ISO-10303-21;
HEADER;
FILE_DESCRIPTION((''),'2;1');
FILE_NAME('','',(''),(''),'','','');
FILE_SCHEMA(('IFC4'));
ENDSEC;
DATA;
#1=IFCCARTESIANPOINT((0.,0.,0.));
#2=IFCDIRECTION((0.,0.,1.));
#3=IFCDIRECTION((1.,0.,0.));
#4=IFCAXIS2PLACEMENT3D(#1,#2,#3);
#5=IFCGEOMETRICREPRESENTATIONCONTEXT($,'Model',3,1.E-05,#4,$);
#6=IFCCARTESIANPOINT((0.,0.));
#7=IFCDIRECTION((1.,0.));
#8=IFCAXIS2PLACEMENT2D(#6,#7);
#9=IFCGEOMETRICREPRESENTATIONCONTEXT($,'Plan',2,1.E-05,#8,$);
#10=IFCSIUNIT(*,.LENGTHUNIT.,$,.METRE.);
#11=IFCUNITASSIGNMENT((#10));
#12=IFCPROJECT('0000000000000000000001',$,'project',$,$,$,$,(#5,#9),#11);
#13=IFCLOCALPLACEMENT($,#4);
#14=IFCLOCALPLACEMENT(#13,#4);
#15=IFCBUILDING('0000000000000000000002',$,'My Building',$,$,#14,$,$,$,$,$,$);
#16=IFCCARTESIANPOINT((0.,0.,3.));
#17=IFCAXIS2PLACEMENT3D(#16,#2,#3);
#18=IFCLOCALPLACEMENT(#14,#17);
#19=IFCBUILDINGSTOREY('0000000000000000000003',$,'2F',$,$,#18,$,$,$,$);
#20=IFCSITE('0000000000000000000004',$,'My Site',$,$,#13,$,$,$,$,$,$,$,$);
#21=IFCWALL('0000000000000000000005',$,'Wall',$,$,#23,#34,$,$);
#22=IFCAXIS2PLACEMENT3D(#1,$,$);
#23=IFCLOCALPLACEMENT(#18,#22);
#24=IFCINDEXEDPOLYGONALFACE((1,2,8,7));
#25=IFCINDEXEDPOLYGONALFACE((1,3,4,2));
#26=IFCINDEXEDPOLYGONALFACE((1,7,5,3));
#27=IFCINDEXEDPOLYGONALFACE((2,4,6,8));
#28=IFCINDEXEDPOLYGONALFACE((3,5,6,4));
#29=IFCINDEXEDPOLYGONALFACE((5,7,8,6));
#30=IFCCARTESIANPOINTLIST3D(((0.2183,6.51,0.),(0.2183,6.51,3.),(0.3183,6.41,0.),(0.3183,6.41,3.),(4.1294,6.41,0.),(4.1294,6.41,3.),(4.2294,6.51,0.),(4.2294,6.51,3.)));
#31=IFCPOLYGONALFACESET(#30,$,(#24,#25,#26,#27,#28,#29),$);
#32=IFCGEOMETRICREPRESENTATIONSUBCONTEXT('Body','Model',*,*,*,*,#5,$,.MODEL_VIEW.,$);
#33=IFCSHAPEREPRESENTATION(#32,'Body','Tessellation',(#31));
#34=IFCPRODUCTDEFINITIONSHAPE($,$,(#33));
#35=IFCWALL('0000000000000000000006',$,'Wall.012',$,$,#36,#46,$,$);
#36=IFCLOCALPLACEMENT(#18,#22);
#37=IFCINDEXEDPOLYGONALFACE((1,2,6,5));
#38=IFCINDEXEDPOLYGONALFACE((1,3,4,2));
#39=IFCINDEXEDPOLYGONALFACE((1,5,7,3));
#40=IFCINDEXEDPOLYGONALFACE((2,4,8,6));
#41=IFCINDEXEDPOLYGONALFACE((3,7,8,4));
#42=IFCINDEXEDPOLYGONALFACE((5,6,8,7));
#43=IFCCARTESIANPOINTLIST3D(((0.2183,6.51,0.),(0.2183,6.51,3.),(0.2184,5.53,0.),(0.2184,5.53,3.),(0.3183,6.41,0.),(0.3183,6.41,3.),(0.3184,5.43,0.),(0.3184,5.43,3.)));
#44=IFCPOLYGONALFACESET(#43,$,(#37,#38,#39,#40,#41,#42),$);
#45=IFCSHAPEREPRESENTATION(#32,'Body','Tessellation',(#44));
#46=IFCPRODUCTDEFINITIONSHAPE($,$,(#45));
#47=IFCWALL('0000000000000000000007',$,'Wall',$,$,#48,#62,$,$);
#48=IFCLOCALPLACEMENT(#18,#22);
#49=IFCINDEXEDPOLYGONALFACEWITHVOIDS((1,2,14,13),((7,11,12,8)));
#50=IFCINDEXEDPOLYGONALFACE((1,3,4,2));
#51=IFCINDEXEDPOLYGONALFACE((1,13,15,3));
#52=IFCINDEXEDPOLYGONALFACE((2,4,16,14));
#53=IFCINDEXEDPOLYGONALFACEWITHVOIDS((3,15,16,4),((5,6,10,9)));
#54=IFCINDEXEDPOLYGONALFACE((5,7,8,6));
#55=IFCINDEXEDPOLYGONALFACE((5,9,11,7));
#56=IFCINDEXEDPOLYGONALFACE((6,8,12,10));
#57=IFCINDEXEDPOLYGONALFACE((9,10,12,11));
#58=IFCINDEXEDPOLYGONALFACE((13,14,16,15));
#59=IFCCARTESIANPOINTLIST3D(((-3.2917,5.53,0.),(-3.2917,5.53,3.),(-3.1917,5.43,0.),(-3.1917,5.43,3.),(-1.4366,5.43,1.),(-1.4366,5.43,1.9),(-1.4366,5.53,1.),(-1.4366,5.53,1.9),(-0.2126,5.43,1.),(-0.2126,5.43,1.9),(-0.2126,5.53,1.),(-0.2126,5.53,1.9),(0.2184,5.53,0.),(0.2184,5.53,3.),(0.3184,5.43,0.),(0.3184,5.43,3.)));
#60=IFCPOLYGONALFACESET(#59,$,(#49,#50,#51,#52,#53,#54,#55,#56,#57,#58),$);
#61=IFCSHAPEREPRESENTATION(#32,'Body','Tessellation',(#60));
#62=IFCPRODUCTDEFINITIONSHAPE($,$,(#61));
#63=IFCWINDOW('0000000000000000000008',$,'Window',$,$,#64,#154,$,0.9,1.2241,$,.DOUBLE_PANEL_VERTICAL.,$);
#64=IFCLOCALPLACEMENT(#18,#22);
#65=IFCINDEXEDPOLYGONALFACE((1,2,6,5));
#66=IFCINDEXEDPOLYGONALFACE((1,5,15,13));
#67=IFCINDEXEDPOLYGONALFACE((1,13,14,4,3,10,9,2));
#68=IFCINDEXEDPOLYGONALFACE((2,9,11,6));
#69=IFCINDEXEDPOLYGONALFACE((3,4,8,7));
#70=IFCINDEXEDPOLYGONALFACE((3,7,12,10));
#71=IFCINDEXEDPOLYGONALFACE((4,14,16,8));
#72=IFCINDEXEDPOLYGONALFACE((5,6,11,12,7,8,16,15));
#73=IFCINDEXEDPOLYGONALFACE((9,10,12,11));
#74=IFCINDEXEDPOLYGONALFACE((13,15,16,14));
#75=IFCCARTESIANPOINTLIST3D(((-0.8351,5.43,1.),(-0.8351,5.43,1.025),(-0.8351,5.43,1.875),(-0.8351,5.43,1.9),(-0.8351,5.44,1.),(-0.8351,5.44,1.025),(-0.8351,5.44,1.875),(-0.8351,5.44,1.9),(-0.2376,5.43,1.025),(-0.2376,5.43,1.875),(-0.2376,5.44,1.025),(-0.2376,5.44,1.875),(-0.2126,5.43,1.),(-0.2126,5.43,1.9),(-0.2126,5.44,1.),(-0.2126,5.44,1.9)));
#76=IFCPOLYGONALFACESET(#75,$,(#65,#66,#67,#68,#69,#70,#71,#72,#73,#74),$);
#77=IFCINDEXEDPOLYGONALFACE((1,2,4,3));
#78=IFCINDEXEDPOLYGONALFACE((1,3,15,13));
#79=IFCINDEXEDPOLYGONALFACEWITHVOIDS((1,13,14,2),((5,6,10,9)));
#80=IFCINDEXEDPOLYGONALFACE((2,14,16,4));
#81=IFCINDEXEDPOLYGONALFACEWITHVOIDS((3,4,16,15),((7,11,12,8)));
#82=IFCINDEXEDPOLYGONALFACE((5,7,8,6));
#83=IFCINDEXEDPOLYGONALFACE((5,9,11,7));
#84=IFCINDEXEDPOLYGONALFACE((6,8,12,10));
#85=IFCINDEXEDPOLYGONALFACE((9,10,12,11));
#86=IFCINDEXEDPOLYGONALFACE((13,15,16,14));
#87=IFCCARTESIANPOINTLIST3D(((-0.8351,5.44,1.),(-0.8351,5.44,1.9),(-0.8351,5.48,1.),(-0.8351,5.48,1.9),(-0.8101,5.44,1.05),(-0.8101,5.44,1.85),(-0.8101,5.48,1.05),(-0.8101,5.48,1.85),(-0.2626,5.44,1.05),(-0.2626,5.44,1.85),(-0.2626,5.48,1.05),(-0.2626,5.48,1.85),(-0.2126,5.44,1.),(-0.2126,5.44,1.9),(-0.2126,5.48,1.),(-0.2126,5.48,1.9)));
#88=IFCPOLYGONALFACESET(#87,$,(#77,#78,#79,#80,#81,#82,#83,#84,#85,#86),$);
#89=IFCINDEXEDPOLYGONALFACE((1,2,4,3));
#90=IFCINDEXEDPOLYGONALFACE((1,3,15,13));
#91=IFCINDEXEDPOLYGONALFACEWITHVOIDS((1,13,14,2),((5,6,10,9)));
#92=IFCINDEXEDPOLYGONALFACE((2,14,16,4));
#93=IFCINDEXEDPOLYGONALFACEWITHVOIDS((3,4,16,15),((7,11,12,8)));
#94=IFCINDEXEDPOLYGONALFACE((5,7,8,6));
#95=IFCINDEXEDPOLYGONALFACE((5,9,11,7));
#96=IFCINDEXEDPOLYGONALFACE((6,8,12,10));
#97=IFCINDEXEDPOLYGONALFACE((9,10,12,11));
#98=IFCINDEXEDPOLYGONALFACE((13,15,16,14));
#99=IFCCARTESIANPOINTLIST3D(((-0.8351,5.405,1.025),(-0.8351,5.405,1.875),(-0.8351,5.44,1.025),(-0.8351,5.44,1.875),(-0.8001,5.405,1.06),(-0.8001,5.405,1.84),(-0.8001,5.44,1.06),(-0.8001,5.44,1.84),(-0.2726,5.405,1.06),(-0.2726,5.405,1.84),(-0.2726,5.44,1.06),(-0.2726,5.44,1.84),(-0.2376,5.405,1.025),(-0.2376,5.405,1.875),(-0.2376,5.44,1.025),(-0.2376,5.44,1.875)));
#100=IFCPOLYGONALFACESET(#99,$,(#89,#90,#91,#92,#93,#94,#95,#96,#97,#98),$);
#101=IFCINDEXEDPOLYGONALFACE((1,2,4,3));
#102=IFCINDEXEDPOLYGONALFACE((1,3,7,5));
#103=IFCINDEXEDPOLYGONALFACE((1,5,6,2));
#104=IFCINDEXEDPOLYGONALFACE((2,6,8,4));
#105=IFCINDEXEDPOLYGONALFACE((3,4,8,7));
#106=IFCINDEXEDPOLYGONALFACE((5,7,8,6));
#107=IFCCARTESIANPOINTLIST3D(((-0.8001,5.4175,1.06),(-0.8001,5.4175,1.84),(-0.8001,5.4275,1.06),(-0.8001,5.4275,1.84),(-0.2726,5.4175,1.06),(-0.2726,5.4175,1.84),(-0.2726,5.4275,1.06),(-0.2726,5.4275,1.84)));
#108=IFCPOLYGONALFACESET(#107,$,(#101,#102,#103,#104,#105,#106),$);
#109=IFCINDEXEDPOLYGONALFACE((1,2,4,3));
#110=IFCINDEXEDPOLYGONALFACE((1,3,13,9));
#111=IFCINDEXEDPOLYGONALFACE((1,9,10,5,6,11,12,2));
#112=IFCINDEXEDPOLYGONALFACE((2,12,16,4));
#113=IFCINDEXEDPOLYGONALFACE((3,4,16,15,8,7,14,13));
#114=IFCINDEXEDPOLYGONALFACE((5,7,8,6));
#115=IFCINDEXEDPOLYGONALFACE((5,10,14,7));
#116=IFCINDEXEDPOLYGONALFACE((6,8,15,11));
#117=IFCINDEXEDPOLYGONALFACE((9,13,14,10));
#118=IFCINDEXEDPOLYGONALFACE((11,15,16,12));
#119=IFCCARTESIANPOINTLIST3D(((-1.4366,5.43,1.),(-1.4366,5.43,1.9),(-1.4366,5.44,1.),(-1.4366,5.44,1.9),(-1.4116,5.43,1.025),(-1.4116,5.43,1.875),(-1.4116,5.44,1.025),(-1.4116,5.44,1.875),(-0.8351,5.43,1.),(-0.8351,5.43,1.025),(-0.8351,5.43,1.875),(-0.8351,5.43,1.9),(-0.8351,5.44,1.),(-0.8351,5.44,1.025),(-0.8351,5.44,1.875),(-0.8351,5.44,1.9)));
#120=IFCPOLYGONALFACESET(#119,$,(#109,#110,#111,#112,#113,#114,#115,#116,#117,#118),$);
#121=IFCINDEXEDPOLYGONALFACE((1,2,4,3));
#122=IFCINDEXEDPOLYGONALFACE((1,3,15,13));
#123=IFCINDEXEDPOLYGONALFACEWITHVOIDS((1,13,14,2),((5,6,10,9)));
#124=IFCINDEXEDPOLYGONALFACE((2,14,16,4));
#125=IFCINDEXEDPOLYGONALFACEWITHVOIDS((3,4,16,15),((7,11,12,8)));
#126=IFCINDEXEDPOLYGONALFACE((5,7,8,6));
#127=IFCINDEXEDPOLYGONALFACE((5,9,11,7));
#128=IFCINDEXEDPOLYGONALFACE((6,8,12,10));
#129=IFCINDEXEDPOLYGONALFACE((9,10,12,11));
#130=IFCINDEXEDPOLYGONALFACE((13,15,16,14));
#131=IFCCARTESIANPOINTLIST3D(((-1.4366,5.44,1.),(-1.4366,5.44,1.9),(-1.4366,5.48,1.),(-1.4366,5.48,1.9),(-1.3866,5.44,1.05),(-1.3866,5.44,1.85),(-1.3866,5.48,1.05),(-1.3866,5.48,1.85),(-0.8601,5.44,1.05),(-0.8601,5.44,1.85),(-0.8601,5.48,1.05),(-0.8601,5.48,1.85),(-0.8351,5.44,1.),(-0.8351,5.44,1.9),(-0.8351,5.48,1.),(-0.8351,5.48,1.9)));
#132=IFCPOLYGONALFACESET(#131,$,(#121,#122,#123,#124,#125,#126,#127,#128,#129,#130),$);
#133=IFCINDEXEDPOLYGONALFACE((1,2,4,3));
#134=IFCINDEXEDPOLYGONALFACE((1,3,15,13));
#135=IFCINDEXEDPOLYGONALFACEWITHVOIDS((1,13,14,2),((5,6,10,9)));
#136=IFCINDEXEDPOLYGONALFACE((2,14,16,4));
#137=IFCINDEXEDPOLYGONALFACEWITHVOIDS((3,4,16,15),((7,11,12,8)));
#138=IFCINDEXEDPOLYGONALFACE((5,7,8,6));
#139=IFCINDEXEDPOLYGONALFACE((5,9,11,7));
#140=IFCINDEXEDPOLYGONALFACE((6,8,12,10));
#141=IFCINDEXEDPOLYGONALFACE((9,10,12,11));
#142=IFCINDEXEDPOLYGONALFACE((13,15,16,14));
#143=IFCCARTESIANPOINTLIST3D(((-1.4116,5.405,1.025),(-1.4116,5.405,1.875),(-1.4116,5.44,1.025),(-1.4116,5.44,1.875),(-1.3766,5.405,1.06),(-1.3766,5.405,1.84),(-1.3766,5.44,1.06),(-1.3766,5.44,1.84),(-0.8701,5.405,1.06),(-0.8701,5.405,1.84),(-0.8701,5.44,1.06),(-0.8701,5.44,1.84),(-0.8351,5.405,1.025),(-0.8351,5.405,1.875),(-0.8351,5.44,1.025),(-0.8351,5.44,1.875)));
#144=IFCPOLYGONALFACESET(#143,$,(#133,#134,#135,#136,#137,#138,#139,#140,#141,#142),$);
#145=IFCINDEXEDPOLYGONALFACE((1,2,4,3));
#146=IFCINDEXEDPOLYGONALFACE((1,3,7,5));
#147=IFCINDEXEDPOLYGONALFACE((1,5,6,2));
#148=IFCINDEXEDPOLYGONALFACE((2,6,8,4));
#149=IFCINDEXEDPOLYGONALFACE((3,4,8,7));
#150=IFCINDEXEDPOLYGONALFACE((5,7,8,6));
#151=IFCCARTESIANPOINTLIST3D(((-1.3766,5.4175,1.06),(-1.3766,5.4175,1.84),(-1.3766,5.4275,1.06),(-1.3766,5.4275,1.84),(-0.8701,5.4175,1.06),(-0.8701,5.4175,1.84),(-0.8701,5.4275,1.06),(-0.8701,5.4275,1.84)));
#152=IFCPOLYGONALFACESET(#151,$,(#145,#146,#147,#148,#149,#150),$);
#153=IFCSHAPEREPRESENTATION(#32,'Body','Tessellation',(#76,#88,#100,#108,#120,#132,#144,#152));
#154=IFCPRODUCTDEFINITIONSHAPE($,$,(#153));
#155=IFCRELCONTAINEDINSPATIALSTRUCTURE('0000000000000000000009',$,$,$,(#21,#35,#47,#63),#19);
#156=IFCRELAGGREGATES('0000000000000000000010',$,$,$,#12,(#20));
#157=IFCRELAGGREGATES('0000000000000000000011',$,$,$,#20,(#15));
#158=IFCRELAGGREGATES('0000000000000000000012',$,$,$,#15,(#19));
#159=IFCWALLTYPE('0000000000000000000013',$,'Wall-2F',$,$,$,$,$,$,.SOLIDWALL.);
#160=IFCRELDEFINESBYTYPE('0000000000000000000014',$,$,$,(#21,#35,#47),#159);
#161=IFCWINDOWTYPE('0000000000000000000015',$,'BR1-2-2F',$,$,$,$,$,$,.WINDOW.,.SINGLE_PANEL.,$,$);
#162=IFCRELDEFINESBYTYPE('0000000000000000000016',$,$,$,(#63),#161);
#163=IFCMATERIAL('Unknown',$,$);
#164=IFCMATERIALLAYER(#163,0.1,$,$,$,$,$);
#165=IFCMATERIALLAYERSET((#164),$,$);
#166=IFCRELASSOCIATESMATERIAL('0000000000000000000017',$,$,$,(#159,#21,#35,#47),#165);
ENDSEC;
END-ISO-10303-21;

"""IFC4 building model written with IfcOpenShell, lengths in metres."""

from ifc_helpers import new_model, entity, si_unit, frame, origin_with_axes, origin_2d_with_axis, place, context, subcontext, project, spatial, line, indexed_curve, outline, extrude, shape, source, transform, mapped, material, layer, layer_set, layer_usage, type_object, type_shapes, element, fill, save


model = new_model("IFC4")

# Units and contexts
model_context = context("Model", 3, precision=1e-05, world=origin_with_axes())
plan_context = context("Plan", 2, precision=1e-05, world=origin_2d_with_axis())
body_context_1 = subcontext(model_context, "Body", "Model", "MODEL_VIEW")
body_context_2 = subcontext(plan_context, "Body", "Plan", "PLAN_VIEW")
ifc_project = project(units=[si_unit("LENGTHUNIT", "METRE")], contexts=[model_context, plan_context])

# Site, building, storey
site_placement = place(None, origin_with_axes())
site = spatial("IfcSite", under=ifc_project, at=site_placement, Name="My Site")
building_placement = place(site_placement, origin_with_axes())
building = spatial("IfcBuilding", under=site, at=building_placement, Name="My Building")
storey_placement = place(building_placement, frame((0.0, 0.0, 3.0), z_axis=(0.0, 0.0, 1.0), x_axis=(1.0, 0.0, 0.0)))
storey = spatial("IfcBuildingStorey", under=building, at=storey_placement, Name="2F")

# Walls
ifc_material = material(Name="Unknown")
ifc_layer_1 = layer(ifc_material, 0.1)
ifc_layer_set_1 = layer_set([ifc_layer_1])
ifc_layer_usage_1 = layer_usage(ifc_layer_set_1, "AXIS2", "POSITIVE", 0.0)
wall_type_1 = type_object("IfcWallType", Name="Wall-2F", PredefinedType="SOLIDWALL", material=ifc_layer_set_1)
wall_1_placement = place(storey_placement, frame((4.2294, 6.51, 0.0), z_axis=(0.0, 0.0, 1.0), x_axis=(-1.0, 0.0, 0.0)))
element("IfcWall", 1, at=wall_1_placement, inside=storey, type_object=wall_type_1, material=ifc_layer_usage_1, Name="Wall", context=body_context_1, shape_type="SweptSolid", body=[
    extrude(outline(indexed_curve([(0.0, 0.0), (0.1, 0.1), (3.9111, 0.1), (4.0111, 0.0)], segments=[line(1, 2, 3, 4, 1)])), origin_with_axes(), (0.0, 0.0, 1.0), 3.0),
])
ifc_layer_usage_2 = layer_usage(ifc_layer_set_1, "AXIS2", "POSITIVE", 0.0)
wall_2_placement = place(storey_placement, frame((0.2183, 6.51, 0.0), z_axis=(0.0, 0.0, 1.0), x_axis=(0.0, -1.0, 0.0)))
element("IfcWall", 2, at=wall_2_placement, inside=storey, type_object=wall_type_1, material=ifc_layer_usage_2, Name="Wall.012", context=body_context_1, shape_type="SweptSolid", body=[
    extrude(outline(indexed_curve([(0.0, 0.0), (0.1, 0.1), (1.08, 0.1), (0.98, 0.0)], segments=[line(1, 2, 3, 4, 1)])), origin_with_axes(), (0.0, 0.0, 1.0), 3.0),
])

# Wall, opening, window
ifc_layer_usage_3 = layer_usage(ifc_layer_set_1, "AXIS2", "POSITIVE", 0.0)
wall_3_placement = place(storey_placement, frame((0.2184, 5.53, 0.0), z_axis=(0.0, 0.0, 1.0), x_axis=(-1.0, 0.0, 0.0)))
wall_3 = element("IfcWall", 3, at=wall_3_placement, inside=storey, type_object=wall_type_1, material=ifc_layer_usage_3, Name="Wall", context=body_context_1, shape_type="SweptSolid", body=[
    extrude(outline(indexed_curve([(0.0, 0.0), (-0.1, 0.1), (3.41, 0.1), (3.51, 0.0)], segments=[line(1, 2, 3, 4, 1)])), origin_with_axes(), (0.0, 0.0, 1.0), 3.0),
])
shared_shape_1 = source(origin_with_axes(), body_context_1, "Body", "SweptSolid", [
    extrude(outline(indexed_curve([(0.0, 0.0), (1.2241, 0.0), (1.2241, 0.9), (0.0, 0.9)], segments=[line(1, 2, 3, 4, 1)])), frame((0.0, -0.6, 0.0), z_axis=(0.0, -1.0, 0.0), x_axis=(1.0, 0.0, 0.0)), (0.0, 0.0, -1.0), 1.2),
])
opening_1_placement = place(wall_3_placement, frame((0.4309, 0.0, 1.0), z_axis=(0.0, 0.0, 1.0), x_axis=(1.0, 0.0, 0.0)))
opening_1 = element("IfcOpeningElement", 4, at=opening_1_placement, cuts=wall_3, PredefinedType="OPENING", context=body_context_1, shape_type="MappedRepresentation", body=[
    mapped(shared_shape_1, transform((0.0, 0.0, 0.0), x_axis=(1.0, 0.0, 0.0), y_axis=(0.0, 1.0, 0.0), z_axis=(0.0, 0.0, 1.0), scale=1.0)),
])
window_type_1 = type_object("IfcWindowType", Name="BR1-2-2F", PartitioningType="SINGLE_PANEL", PredefinedType="WINDOW")
shared_shape_2 = source(origin_with_axes(), body_context_1, "Body", "SweptSolid", [
    extrude(outline(indexed_curve([(0.6225, 0.0), (0.0, 0.0), (0.0, 0.9), (0.6225, 0.9), (0.6225, 0.875), (0.025, 0.875), (0.025, 0.025), (0.6225, 0.025)], segments=[line(1, 2, 3, 4, 5, 6, 7, 8, 1)])), frame((0.0, 0.09, 0.0), z_axis=(0.0, -1.0, 0.0), x_axis=(1.0, 0.0, 0.0)), (0.0, 0.0, -1.0), 0.01),
    extrude(outline(indexed_curve([(0.0, 0.0), (0.6225, 0.0), (0.6225, 0.9), (0.0, 0.9)], segments=[line(1, 2, 3, 4, 1)]), holes=[indexed_curve([(0.05, 0.05), (0.5975, 0.05), (0.5975, 0.85), (0.05, 0.85)], segments=[line(1, 2, 3, 4, 1)])]), frame((0.0, 0.05, 0.0), z_axis=(0.0, -1.0, 0.0), x_axis=(1.0, 0.0, 0.0)), (0.0, 0.0, -1.0), 0.04),
    extrude(outline(indexed_curve([(0.0, 0.0), (0.5975, 0.0), (0.5975, 0.85), (0.0, 0.85)], segments=[line(1, 2, 3, 4, 1)]), holes=[indexed_curve([(0.035, 0.035), (0.5625, 0.035), (0.5625, 0.815), (0.035, 0.815)], segments=[line(1, 2, 3, 4, 1)])]), frame((0.025, 0.09, 0.025), z_axis=(0.0, -1.0, 0.0), x_axis=(1.0, 0.0, 0.0)), (0.0, 0.0, -1.0), 0.035),
    extrude(outline(indexed_curve([(0.035, 0.035), (0.5625, 0.035), (0.5625, 0.815), (0.035, 0.815)], segments=[line(1, 2, 3, 4, 1)])), frame((0.025, 0.1025, 0.025), z_axis=(0.0, -1.0, 0.0), x_axis=(1.0, 0.0, 0.0)), (0.0, 0.0, -1.0), 0.01),
    extrude(outline(indexed_curve([(0.0, 0.9), (0.6016, 0.9), (0.6016, 0.0), (0.0, 0.0), (0.0, 0.025), (0.5766, 0.025), (0.5766, 0.875), (0.0, 0.875)], segments=[line(1, 2, 3, 4, 5, 6, 7, 8, 1)])), frame((0.6225, 0.09, 0.0), z_axis=(0.0, -1.0, 0.0), x_axis=(1.0, 0.0, 0.0)), (0.0, 0.0, -1.0), 0.01),
    extrude(outline(indexed_curve([(0.0, 0.0), (0.6016, 0.0), (0.6016, 0.9), (0.0, 0.9)], segments=[line(1, 2, 3, 4, 1)]), holes=[indexed_curve([(0.025, 0.05), (0.5516, 0.05), (0.5516, 0.85), (0.025, 0.85)], segments=[line(1, 2, 3, 4, 1)])]), frame((0.6225, 0.05, 0.0), z_axis=(0.0, -1.0, 0.0), x_axis=(1.0, 0.0, 0.0)), (0.0, 0.0, -1.0), 0.04),
    extrude(outline(indexed_curve([(0.0, 0.0), (0.5766, 0.0), (0.5766, 0.85), (0.0, 0.85)], segments=[line(1, 2, 3, 4, 1)]), holes=[indexed_curve([(0.035, 0.035), (0.5416, 0.035), (0.5416, 0.815), (0.035, 0.815)], segments=[line(1, 2, 3, 4, 1)])]), frame((0.6225, 0.09, 0.025), z_axis=(0.0, -1.0, 0.0), x_axis=(1.0, 0.0, 0.0)), (0.0, 0.0, -1.0), 0.035),
    extrude(outline(indexed_curve([(0.035, 0.035), (0.5416, 0.035), (0.5416, 0.815), (0.035, 0.815)], segments=[line(1, 2, 3, 4, 1)])), frame((0.6225, 0.1025, 0.025), z_axis=(0.0, -1.0, 0.0), x_axis=(1.0, 0.0, 0.0)), (0.0, 0.0, -1.0), 0.01),
])
shared_shape_3 = source(origin_with_axes(), body_context_2, "Body", "Curve2D", [
    entity("IfcIndexedPolyCurve", entity("IfcCartesianPointList2D", [[0.05, 0.05], [0.5975, 0.05]])),
    entity("IfcIndexedPolyCurve", entity("IfcCartesianPointList2D", [[0.0, 0.1], [0.025, 0.1], [0.025, 0.09], [0.05, 0.09], [0.05, 0.05], [0.0, 0.05]]), [entity("IfcLineIndex", [1, 2, 3, 4, 5, 6, 1])]),
    entity("IfcIndexedPolyCurve", entity("IfcCartesianPointList2D", [[0.6225, 0.1], [0.6225, 0.1], [0.6225, 0.09], [0.5975, 0.09], [0.5975, 0.05], [0.6225, 0.05]])),
    entity("IfcIndexedPolyCurve", entity("IfcCartesianPointList2D", [[0.025, 0.09], [0.06, 0.09], [0.06, 0.125], [0.025, 0.125]]), [entity("IfcLineIndex", [1, 2, 3, 4, 1])]),
    entity("IfcIndexedPolyCurve", entity("IfcCartesianPointList2D", [[0.6225, 0.09], [0.5875, 0.09], [0.5875, 0.125], [0.6225, 0.125]]), [entity("IfcLineIndex", [1, 2, 3, 4, 1])]),
    entity("IfcIndexedPolyCurve", entity("IfcCartesianPointList2D", [[0.06, 0.09], [0.5875, 0.09]])),
    entity("IfcIndexedPolyCurve", entity("IfcCartesianPointList2D", [[0.06, 0.125], [0.5875, 0.125]])),
    entity("IfcIndexedPolyCurve", entity("IfcCartesianPointList2D", [[0.06, 0.1075], [0.5875, 0.1075]])),
    entity("IfcIndexedPolyCurve", entity("IfcCartesianPointList2D", [[0.6475, 0.05], [1.1741, 0.05]])),
    entity("IfcIndexedPolyCurve", entity("IfcCartesianPointList2D", [[0.6225, 0.1], [0.6225, 0.1], [0.6225, 0.09], [0.6475, 0.09], [0.6475, 0.05], [0.6225, 0.05]])),
    entity("IfcIndexedPolyCurve", entity("IfcCartesianPointList2D", [[1.2241, 0.1], [1.1991, 0.1], [1.1991, 0.09], [1.1741, 0.09], [1.1741, 0.05], [1.2241, 0.05]]), [entity("IfcLineIndex", [1, 2, 3, 4, 5, 6, 1])]),
    entity("IfcIndexedPolyCurve", entity("IfcCartesianPointList2D", [[0.6225, 0.09], [0.6575, 0.09], [0.6575, 0.125], [0.6225, 0.125]]), [entity("IfcLineIndex", [1, 2, 3, 4, 1])]),
    entity("IfcIndexedPolyCurve", entity("IfcCartesianPointList2D", [[1.1991, 0.09], [1.1641, 0.09], [1.1641, 0.125], [1.1991, 0.125]]), [entity("IfcLineIndex", [1, 2, 3, 4, 1])]),
    entity("IfcIndexedPolyCurve", entity("IfcCartesianPointList2D", [[0.6575, 0.09], [1.1641, 0.09]])),
    entity("IfcIndexedPolyCurve", entity("IfcCartesianPointList2D", [[0.6575, 0.125], [1.1641, 0.125]])),
    entity("IfcIndexedPolyCurve", entity("IfcCartesianPointList2D", [[0.6575, 0.1075], [1.1641, 0.1075]])),
])
type_shapes(window_type_1, [shared_shape_2, shared_shape_3])
window_1_placement = place(opening_1_placement, frame((0.0, 0.0, 0.0), z_axis=(0.0, 0.0, 1.0), x_axis=(1.0, 0.0, 0.0)))
window_1 = element("IfcWindow", 5, at=window_1_placement, inside=storey, type_object=window_type_1, Name="Window", OverallHeight=0.9, OverallWidth=1.2241, PartitioningType="DOUBLE_PANEL_VERTICAL", shapes=[
    shape(body_context_1, "Body", "MappedRepresentation", [mapped(shared_shape_2, transform((0.0, 0.0, 0.0), x_axis=(1.0, 0.0, 0.0), y_axis=(0.0, 1.0, 0.0), z_axis=(0.0, 0.0, 1.0), scale=1.0))]),
    shape(body_context_2, "Body", "MappedRepresentation", [mapped(shared_shape_3, transform((0.0, 0.0, 0.0), x_axis=(1.0, 0.0, 0.0), y_axis=(0.0, 1.0, 0.0), z_axis=(0.0, 0.0, 1.0), scale=1.0))]),
])
fill(opening_1, window_1)

save(model, "model.ifc")
